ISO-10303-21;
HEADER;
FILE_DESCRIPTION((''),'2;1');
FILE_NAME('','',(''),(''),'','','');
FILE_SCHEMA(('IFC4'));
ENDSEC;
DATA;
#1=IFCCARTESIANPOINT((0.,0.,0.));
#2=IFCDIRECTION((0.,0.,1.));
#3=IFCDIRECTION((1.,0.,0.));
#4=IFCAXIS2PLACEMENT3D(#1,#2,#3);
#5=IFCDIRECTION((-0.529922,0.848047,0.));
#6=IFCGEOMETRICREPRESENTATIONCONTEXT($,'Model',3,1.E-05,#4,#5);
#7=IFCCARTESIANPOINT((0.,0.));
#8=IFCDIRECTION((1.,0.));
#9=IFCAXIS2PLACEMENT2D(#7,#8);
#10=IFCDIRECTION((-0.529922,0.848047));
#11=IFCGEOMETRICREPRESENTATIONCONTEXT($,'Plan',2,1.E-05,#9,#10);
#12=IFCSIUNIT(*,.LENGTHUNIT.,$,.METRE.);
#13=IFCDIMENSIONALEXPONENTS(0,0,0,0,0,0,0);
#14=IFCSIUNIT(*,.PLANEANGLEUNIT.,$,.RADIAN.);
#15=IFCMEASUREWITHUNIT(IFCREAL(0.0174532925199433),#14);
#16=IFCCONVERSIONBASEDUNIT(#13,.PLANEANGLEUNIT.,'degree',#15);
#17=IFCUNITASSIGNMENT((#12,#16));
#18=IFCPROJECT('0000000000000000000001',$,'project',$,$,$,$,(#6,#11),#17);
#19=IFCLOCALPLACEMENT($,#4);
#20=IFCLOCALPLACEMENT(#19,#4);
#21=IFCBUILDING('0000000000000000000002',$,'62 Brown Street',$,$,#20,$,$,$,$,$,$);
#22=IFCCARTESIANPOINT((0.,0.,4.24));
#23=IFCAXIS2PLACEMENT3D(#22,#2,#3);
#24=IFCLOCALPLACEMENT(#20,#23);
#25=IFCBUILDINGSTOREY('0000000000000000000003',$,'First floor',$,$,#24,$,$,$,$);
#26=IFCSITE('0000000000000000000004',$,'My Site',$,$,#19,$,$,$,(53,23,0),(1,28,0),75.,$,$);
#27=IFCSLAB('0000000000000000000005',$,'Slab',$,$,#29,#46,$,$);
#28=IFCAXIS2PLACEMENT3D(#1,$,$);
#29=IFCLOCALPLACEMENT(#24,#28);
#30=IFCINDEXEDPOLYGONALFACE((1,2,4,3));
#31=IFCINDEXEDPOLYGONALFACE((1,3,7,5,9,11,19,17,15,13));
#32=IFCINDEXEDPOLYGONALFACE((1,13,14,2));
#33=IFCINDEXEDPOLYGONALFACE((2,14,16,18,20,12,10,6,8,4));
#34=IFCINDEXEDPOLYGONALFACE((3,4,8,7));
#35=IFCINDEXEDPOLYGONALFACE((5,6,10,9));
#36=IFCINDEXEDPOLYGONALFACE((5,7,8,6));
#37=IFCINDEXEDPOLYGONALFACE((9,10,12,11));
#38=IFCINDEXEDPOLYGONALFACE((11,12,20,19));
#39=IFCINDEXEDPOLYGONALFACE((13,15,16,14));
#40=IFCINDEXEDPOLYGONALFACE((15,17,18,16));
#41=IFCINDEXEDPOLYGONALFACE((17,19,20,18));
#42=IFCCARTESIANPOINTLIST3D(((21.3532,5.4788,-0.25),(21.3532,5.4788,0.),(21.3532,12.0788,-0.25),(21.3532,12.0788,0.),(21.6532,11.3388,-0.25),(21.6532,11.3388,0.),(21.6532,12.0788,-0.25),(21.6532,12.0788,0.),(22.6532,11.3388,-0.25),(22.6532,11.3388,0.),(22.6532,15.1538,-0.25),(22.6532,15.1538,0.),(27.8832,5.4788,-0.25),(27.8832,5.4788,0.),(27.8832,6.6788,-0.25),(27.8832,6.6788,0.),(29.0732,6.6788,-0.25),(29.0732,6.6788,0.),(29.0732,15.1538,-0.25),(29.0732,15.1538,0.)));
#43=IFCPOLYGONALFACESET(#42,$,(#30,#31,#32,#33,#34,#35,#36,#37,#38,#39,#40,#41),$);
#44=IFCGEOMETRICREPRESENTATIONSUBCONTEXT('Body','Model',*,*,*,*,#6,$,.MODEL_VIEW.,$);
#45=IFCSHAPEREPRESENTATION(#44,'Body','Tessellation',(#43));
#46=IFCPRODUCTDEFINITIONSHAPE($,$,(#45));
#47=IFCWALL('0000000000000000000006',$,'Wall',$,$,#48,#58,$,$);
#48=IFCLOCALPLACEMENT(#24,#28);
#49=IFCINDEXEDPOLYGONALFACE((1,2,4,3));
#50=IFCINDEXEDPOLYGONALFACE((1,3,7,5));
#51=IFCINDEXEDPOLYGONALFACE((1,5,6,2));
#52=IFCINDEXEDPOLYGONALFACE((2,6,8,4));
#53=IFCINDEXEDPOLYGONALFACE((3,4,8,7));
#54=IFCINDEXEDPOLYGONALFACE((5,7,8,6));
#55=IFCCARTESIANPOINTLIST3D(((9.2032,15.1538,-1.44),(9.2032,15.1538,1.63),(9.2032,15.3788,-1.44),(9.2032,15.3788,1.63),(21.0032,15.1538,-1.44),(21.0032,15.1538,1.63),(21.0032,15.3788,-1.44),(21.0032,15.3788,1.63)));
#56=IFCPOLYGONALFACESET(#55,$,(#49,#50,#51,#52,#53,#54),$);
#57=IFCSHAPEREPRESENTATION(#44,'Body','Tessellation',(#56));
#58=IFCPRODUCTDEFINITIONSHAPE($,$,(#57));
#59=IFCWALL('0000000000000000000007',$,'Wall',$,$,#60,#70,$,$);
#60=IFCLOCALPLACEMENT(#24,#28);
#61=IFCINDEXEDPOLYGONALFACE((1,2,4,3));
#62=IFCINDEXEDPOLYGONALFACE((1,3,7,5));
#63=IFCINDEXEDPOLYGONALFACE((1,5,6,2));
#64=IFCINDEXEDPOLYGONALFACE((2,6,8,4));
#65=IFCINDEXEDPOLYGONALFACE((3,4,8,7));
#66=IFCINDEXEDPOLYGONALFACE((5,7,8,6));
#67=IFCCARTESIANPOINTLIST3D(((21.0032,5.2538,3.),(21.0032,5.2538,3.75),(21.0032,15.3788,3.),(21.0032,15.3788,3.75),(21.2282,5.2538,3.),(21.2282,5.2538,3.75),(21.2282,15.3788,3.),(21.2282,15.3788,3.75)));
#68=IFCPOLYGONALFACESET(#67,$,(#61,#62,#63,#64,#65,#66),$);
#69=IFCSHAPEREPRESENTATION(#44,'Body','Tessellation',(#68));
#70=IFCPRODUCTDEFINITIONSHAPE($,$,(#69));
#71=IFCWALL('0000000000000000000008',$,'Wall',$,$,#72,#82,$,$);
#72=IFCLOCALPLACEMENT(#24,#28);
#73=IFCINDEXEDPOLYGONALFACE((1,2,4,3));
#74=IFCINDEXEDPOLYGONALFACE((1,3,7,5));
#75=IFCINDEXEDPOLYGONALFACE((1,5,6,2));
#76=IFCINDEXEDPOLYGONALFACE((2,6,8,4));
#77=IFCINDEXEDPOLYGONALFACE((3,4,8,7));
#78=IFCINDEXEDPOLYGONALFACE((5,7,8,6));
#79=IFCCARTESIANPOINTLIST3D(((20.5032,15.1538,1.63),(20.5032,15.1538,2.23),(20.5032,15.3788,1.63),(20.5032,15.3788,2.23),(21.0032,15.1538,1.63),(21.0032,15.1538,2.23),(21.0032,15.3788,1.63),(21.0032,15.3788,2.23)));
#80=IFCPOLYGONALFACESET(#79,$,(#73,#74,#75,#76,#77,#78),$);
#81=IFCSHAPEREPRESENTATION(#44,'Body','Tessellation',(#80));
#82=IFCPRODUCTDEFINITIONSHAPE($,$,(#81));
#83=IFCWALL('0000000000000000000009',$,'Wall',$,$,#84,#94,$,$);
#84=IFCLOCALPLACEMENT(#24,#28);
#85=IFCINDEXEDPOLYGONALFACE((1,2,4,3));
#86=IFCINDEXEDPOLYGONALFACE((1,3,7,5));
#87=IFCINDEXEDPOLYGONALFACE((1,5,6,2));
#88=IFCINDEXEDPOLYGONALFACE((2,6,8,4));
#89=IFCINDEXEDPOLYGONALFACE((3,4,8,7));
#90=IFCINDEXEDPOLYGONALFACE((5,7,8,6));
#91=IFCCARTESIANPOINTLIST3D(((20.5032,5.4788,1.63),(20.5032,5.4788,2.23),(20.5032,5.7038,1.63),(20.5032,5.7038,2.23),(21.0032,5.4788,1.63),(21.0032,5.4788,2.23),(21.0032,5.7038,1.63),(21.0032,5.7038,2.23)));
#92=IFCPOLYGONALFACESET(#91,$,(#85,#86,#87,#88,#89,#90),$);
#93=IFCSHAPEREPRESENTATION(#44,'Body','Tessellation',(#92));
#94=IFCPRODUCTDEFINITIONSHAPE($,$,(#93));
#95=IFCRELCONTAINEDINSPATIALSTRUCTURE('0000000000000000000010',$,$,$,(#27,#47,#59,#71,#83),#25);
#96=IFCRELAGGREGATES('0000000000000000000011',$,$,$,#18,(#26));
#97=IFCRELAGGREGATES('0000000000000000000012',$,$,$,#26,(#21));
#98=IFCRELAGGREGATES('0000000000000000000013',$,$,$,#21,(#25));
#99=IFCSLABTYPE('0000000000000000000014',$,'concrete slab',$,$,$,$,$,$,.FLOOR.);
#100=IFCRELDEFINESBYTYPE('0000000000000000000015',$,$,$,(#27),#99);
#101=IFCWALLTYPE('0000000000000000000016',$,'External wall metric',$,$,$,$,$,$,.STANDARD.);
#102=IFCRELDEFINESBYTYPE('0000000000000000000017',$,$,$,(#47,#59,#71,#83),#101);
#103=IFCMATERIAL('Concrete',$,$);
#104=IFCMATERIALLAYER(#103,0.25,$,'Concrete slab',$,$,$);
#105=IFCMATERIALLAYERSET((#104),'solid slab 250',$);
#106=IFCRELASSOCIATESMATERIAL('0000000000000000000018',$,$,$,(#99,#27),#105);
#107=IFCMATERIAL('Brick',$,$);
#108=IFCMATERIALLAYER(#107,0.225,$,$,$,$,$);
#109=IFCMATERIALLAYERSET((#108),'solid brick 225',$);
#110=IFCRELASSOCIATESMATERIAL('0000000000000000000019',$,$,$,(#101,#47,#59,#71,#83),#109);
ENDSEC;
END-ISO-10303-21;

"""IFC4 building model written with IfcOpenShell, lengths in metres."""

from ifc_helpers import new_model, entity, si_unit, converted_unit, direction, frame, origin_with_axes, origin_2d_with_axis, place, context, subcontext, project, spatial, indexed_curve, outline, extrude, material, layer, layer_set, layer_usage, type_object, element, save


model = new_model("IFC4")

# Units and contexts
model_context = context("Model", 3, precision=1e-05, world=origin_with_axes(), true_north=direction((-0.529922, 0.848047, 0.0)))
plan_context = context("Plan", 2, precision=1e-05, world=origin_2d_with_axis(), true_north=direction((-0.529922, 0.848047)))
body_context = subcontext(model_context, "Body", "Model", "MODEL_VIEW")
ifc_project = project(units=[si_unit("LENGTHUNIT", "METRE"), converted_unit("PLANEANGLEUNIT", "degree", entity("IfcReal", 0.0174532925199433), si_unit("PLANEANGLEUNIT", "RADIAN"), dimensions=[0, 0, 0, 0, 0, 0, 0])], contexts=[model_context, plan_context])

# Site, building, storey
site_placement = place(None, origin_with_axes())
site = spatial("IfcSite", under=ifc_project, at=site_placement, Name="My Site", RefLatitude=(53, 23, 0), RefLongitude=(1, 28, 0), RefElevation=75.0)
building_placement = place(site_placement, origin_with_axes())
building = spatial("IfcBuilding", under=site, at=building_placement, Name="62 Brown Street")
storey_placement = place(building_placement, frame((0.0, 0.0, 4.24), z_axis=(0.0, 0.0, 1.0), x_axis=(1.0, 0.0, 0.0)))
storey = spatial("IfcBuildingStorey", under=building, at=storey_placement, Name="First floor")

# Shared definitions
ifc_material_1 = material(Name="Concrete")

# Slab
ifc_layer_1 = layer(ifc_material_1, 0.25, Name="Concrete slab")
ifc_layer_set_1 = layer_set([ifc_layer_1], Name="solid slab 250")
ifc_layer_usage_1 = layer_usage(ifc_layer_set_1, "AXIS3", "POSITIVE", 0.0)
slab_type = type_object("IfcSlabType", Name="concrete slab", PredefinedType="FLOOR", material=ifc_layer_set_1)
slab_placement = place(storey_placement, frame((21.3532, 5.4788, -0.25), z_axis=(0.0, 0.0, 1.0), x_axis=(1.0, 0.0, 0.0)))
element("IfcSlab", 1, at=slab_placement, inside=storey, type_object=slab_type, material=ifc_layer_usage_1, Name="Slab", context=body_context, shape_type="SweptSolid", body=[
    extrude(outline(indexed_curve([(6.53, 1.2), (6.53, 0.0), (0.0, 0.0), (0.0, 6.6), (0.3, 6.6), (0.3, 5.86), (1.3, 5.86), (1.3, 9.675), (7.72, 9.675), (7.72, 1.2), (6.53, 1.2)])), None, (0.0, 0.0, 1.0), 0.25),
])

# Walls
ifc_material_2 = material(Name="Brick")
ifc_layer_2 = layer(ifc_material_2, 0.225)
ifc_layer_set_2 = layer_set([ifc_layer_2], Name="solid brick 225")
ifc_layer_usage_2 = layer_usage(ifc_layer_set_2, "AXIS2", "POSITIVE", 0.0)
wall_type_1 = type_object("IfcWallType", Name="External wall metric", PredefinedType="STANDARD", material=ifc_layer_set_2)
wall_1_placement = place(storey_placement, frame((21.0032, 15.3788, -1.44), z_axis=(0.0, 0.0, 1.0), x_axis=(-1.0, 0.0, 0.0)))
element("IfcWall", 2, at=wall_1_placement, inside=storey, type_object=wall_type_1, material=ifc_layer_usage_2, Name="Wall", context=body_context, shape_type="SweptSolid", body=[
    extrude(outline(indexed_curve([(0.0, 0.0), (0.0, 0.225), (11.8, 0.225), (11.8, 0.0), (0.0, 0.0)], self_intersect=False)), origin_with_axes(), (0.0, 0.0, 1.0), 3.07),
])
ifc_layer_usage_3 = layer_usage(ifc_layer_set_2, "AXIS2", "POSITIVE", 0.0)
wall_2_placement = place(storey_placement, frame((21.0032, 15.3788, 3.0), z_axis=(0.0, 0.0, 1.0), x_axis=(0.0, -1.0, 0.0)))
element("IfcWall", 3, at=wall_2_placement, inside=storey, type_object=wall_type_1, material=ifc_layer_usage_3, Name="Wall", context=body_context, shape_type="SweptSolid", body=[
    extrude(outline(indexed_curve([(0.0, 0.0), (0.0, 0.225), (10.125, 0.225), (10.125, 0.0), (0.0, 0.0)], self_intersect=False)), origin_with_axes(), (0.0, 0.0, 1.0), 0.75),
])
ifc_layer_usage_4 = layer_usage(ifc_layer_set_2, "AXIS2", "POSITIVE", 0.0)
wall_3_placement = place(storey_placement, frame((21.0032, 15.3788, 1.63), z_axis=(0.0, 0.0, 1.0), x_axis=(-1.0, 0.0, 0.0)))
element("IfcWall", 4, at=wall_3_placement, inside=storey, type_object=wall_type_1, material=ifc_layer_usage_4, Name="Wall", context=body_context, shape_type="SweptSolid", body=[
    extrude(outline(indexed_curve([(0.0, 0.0), (0.0, 0.225), (0.5, 0.225), (0.5, 0.0), (0.0, 0.0)], self_intersect=False)), origin_with_axes(), (0.0, 0.0, 1.0), 0.6),
])
ifc_layer_usage_5 = layer_usage(ifc_layer_set_2, "AXIS2", "POSITIVE", 0.0)
wall_4_placement = place(storey_placement, frame((20.5032, 5.4788, 1.63), z_axis=(0.0, 0.0, 1.0), x_axis=(1.0, 0.0, 0.0)))
element("IfcWall", 5, at=wall_4_placement, inside=storey, type_object=wall_type_1, material=ifc_layer_usage_5, Name="Wall", context=body_context, shape_type="SweptSolid", body=[
    extrude(outline(indexed_curve([(0.0, 0.0), (0.0, 0.225), (0.5, 0.225), (0.5, 0.0), (0.0, 0.0)], self_intersect=False)), origin_with_axes(), (0.0, 0.0, 1.0), 0.6),
])

save(model, "model.ifc")
